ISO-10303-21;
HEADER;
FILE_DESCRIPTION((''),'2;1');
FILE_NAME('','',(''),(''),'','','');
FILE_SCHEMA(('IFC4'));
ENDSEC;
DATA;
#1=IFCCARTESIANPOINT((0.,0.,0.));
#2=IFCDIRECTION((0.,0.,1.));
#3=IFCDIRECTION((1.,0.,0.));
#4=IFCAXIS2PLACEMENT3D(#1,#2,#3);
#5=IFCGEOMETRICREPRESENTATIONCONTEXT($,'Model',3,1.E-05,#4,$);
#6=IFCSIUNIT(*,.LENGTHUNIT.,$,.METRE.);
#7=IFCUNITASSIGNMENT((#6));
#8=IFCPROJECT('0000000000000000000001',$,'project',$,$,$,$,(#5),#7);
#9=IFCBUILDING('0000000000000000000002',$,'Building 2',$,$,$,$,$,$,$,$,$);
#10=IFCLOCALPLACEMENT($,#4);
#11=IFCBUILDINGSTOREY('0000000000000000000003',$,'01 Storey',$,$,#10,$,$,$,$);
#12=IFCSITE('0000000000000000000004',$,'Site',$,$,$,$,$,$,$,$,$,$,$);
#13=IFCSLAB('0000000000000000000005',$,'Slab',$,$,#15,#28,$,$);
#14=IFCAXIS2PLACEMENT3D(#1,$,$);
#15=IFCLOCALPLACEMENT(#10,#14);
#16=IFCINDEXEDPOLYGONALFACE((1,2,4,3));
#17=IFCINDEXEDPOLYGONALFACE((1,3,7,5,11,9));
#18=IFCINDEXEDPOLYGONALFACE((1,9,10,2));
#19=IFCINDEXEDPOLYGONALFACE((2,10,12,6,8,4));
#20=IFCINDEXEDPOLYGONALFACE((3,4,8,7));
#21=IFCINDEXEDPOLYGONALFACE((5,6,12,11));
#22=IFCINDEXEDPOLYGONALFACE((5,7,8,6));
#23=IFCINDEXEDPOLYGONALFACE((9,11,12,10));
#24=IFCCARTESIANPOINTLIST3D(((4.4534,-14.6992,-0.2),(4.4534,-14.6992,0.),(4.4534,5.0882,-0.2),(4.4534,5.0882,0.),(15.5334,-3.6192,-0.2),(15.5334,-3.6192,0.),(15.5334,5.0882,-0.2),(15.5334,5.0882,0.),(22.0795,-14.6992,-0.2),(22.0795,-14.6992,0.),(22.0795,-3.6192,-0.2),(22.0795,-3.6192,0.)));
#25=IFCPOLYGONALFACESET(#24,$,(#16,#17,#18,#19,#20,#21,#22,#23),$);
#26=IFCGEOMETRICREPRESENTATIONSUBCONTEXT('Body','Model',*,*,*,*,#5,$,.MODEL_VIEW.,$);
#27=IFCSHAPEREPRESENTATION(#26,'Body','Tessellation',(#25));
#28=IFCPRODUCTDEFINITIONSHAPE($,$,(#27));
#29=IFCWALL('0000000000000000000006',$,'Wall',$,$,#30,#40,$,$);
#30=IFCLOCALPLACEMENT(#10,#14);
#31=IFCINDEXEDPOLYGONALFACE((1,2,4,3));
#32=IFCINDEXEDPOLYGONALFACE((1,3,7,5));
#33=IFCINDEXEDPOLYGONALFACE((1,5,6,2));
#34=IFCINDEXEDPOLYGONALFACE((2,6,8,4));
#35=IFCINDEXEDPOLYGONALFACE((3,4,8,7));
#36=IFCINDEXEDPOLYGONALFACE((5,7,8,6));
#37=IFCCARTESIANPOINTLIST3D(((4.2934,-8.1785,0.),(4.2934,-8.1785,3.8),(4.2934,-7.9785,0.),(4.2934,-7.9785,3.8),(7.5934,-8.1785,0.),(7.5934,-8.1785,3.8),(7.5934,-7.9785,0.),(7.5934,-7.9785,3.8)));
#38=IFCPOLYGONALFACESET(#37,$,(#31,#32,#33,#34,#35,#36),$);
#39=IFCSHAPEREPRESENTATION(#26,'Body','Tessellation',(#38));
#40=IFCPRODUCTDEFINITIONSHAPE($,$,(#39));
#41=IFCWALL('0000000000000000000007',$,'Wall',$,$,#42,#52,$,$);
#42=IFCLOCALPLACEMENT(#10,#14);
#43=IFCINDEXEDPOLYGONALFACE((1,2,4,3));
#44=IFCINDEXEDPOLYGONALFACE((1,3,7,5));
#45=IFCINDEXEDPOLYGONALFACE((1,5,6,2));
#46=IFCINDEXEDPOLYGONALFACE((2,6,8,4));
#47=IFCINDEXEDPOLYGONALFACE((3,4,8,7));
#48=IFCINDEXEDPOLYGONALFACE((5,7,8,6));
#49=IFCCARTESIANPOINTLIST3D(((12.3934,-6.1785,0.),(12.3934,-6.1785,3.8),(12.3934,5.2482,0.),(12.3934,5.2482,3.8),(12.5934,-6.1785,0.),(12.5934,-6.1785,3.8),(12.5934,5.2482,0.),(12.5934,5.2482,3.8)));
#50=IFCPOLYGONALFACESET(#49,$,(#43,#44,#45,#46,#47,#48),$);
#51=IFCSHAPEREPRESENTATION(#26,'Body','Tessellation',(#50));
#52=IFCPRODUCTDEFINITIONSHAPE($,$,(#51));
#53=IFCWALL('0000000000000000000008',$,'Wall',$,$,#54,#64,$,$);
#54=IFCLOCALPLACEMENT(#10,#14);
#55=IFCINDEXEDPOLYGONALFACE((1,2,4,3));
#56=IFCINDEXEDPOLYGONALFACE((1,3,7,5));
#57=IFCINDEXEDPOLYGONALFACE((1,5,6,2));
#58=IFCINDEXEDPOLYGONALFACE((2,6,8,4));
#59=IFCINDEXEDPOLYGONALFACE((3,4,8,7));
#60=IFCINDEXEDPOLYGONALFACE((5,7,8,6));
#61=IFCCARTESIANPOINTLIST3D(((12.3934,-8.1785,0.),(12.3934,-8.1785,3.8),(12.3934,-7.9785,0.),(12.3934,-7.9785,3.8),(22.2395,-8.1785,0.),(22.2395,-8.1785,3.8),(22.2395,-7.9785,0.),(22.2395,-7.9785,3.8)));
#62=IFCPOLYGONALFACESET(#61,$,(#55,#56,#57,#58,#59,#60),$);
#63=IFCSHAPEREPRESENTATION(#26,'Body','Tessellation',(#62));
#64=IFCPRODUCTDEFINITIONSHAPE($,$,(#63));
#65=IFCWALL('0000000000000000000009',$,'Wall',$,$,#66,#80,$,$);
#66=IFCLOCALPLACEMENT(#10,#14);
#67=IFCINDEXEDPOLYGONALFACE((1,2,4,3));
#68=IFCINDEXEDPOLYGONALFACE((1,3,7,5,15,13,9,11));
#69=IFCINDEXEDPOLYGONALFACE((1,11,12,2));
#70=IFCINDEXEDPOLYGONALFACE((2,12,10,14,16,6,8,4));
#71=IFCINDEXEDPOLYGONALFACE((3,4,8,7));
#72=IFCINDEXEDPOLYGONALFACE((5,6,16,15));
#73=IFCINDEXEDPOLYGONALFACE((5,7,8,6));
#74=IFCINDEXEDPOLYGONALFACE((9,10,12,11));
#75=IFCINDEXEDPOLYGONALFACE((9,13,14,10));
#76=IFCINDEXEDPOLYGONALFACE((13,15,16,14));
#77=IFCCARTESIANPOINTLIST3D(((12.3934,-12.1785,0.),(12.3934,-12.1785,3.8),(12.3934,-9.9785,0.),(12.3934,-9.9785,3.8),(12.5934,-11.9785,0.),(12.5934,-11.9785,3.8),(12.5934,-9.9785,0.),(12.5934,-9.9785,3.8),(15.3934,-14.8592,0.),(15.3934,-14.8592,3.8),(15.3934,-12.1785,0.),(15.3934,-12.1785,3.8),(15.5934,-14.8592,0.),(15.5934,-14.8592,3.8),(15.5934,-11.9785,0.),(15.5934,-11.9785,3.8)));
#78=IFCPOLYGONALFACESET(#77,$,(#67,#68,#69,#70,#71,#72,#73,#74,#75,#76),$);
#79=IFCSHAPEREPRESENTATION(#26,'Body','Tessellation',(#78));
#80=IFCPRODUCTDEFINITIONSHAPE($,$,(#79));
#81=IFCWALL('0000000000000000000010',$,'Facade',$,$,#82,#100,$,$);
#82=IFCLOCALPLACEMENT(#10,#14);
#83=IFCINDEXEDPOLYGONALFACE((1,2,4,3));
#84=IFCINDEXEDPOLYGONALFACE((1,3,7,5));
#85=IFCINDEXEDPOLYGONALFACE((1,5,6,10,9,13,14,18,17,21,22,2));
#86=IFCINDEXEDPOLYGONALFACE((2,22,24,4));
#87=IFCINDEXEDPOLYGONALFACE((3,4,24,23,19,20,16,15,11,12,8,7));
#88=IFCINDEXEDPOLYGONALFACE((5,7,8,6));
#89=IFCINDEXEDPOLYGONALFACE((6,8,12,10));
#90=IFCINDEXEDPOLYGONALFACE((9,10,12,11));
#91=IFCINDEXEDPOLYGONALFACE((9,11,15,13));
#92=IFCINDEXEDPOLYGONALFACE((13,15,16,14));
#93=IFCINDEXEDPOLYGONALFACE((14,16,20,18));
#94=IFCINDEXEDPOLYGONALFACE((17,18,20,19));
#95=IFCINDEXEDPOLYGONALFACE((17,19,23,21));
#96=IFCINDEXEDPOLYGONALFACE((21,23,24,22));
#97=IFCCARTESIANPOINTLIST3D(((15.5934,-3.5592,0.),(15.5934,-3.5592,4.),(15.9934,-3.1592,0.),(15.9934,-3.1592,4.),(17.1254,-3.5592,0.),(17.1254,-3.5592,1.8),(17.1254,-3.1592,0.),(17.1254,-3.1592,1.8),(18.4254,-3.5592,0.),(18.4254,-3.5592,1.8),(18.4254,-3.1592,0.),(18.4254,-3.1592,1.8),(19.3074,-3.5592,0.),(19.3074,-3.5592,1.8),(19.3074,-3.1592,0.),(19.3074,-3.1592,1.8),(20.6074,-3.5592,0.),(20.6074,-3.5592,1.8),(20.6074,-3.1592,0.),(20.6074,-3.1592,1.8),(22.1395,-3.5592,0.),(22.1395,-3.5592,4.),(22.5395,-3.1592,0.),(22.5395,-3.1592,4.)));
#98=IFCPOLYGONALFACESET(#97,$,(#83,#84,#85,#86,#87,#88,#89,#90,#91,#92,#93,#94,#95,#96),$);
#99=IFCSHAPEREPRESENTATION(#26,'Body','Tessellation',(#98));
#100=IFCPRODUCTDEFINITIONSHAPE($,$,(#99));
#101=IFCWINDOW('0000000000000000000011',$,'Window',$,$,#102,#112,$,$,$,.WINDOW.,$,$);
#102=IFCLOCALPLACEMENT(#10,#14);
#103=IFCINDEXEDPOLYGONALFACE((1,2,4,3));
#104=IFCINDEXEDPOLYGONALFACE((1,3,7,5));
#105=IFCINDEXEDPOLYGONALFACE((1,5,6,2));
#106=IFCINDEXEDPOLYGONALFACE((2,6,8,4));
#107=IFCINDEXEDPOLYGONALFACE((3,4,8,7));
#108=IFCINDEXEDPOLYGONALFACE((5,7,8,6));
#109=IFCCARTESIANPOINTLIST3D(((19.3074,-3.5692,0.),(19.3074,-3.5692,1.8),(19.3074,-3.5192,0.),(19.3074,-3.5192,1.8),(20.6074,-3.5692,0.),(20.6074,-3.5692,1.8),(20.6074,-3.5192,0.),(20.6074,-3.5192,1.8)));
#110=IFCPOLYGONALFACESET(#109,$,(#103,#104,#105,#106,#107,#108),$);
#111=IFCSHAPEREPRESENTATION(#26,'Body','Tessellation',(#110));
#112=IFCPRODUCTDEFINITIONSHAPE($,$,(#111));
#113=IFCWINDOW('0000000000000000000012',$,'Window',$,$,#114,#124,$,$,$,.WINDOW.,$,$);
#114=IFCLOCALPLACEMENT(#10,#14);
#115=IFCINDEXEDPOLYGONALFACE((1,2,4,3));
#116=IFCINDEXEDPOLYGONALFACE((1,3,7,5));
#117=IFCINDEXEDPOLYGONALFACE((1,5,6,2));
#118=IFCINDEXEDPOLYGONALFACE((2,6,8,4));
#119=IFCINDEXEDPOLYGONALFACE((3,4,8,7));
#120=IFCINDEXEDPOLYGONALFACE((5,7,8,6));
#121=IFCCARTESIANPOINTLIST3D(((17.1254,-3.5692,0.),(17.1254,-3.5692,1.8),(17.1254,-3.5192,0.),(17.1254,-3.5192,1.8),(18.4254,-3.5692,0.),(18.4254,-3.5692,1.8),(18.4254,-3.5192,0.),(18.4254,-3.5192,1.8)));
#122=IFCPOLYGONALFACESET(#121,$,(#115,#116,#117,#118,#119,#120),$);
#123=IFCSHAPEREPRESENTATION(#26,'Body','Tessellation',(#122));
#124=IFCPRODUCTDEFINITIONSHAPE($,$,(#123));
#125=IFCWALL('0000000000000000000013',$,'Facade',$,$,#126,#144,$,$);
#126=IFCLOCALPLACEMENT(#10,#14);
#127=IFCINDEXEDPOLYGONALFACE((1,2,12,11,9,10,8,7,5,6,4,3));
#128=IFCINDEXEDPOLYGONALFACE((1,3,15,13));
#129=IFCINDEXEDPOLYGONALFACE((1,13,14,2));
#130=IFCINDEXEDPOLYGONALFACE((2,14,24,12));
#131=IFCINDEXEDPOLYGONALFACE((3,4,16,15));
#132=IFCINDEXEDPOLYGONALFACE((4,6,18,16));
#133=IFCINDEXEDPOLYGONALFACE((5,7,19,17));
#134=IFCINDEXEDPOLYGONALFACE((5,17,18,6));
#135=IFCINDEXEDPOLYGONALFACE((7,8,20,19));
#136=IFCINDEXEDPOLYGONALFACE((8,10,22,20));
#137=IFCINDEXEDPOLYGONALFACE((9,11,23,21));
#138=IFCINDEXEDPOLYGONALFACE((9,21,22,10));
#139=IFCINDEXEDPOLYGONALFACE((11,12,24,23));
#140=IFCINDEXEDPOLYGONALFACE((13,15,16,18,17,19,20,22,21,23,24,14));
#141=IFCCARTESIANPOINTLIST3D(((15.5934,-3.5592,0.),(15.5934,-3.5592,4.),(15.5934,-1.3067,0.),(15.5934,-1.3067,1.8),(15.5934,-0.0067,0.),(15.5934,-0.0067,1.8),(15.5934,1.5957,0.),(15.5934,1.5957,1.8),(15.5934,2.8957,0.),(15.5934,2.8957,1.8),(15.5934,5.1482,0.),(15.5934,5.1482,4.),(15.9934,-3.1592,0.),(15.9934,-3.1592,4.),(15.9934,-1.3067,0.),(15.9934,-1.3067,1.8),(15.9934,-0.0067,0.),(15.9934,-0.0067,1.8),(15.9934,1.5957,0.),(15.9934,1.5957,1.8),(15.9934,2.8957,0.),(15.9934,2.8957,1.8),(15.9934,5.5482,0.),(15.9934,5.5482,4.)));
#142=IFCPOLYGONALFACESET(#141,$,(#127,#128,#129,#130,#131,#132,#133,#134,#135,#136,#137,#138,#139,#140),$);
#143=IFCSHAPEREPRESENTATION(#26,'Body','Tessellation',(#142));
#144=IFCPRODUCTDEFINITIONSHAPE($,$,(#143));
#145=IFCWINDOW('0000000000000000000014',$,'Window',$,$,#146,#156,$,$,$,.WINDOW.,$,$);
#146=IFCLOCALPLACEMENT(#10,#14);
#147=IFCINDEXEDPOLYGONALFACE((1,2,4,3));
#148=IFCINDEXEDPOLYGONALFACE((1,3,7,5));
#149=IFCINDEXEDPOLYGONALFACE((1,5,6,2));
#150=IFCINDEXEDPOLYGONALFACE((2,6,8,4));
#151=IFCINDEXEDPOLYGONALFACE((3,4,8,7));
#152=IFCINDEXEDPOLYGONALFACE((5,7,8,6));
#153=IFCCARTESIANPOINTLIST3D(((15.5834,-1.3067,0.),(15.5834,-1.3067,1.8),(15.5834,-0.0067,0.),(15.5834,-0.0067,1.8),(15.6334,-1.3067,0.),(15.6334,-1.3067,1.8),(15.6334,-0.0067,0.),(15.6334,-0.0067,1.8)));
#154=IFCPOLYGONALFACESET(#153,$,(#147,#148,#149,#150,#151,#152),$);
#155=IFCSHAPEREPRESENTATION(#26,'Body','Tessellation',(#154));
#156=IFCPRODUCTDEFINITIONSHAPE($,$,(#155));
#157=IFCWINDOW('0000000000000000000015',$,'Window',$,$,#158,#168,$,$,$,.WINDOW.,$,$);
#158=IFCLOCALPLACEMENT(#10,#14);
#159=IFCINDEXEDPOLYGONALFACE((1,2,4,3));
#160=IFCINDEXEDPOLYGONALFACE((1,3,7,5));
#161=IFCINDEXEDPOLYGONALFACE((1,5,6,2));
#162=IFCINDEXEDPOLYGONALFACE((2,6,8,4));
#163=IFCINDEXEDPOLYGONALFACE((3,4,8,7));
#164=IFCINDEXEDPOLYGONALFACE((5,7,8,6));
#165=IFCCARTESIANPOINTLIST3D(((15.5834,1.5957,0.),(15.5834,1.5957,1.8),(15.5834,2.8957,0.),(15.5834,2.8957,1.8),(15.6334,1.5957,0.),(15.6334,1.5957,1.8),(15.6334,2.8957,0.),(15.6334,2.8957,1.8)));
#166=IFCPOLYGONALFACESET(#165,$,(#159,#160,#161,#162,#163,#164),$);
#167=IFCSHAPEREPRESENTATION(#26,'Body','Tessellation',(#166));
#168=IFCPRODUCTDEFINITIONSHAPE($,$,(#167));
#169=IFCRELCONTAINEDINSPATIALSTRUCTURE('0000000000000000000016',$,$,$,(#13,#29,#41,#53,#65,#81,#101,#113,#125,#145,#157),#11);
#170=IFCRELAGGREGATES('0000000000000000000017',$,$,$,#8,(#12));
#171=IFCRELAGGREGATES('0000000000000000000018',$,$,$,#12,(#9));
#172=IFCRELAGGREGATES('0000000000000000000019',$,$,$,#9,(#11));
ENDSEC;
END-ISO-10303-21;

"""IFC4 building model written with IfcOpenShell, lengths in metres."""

from ifc_helpers import new_model, si_unit, origin_with_axes, place, context, subcontext, project, spatial, line, indexed_curve, outline, extrude, element, fill, save


model = new_model("IFC4")

# Units and contexts
model_context = context("Model", 3, precision=1e-05, world=origin_with_axes())
body_context = subcontext(model_context, "Body", "Model", "MODEL_VIEW")
ifc_project = project(units=[si_unit("LENGTHUNIT", "METRE")], contexts=[model_context])

# Site, building, storey
site = spatial("IfcSite", under=ifc_project, Name="Site")
building = spatial("IfcBuilding", under=site, Name="Building 2")
storey_placement = place(None, origin_with_axes())
storey = spatial("IfcBuildingStorey", under=building, at=storey_placement, Name="01 Storey")

# Slab
slab_placement = place(storey_placement, origin_with_axes())
element("IfcSlab", 1, at=slab_placement, inside=storey, Name="Slab", context=body_context, shape_type="SweptSolid", body=[
    extrude(outline(indexed_curve([(22.0795, -3.6192), (15.5334, -3.6192), (15.5334, 5.0882), (4.4534, 5.0882), (4.4534, -14.6992), (22.0795, -14.6992)], segments=[line(1, 2), line(2, 3), line(3, 4), line(4, 5), line(5, 6)])), origin_with_axes(), (0.0, 0.0, -1.0), 0.2),
])

# Walls
wall_1_placement = place(storey_placement, origin_with_axes())
element("IfcWall", 2, at=wall_1_placement, inside=storey, Name="Wall", context=body_context, shape_type="SweptSolid", body=[
    extrude(outline(indexed_curve([(7.5934, -7.9785), (4.2934, -7.9785), (4.2934, -8.1785), (7.5934, -8.1785)], segments=[line(1, 2), line(2, 3), line(3, 4)])), origin_with_axes(), (0.0, 0.0, 1.0), 3.8),
])
wall_2_placement = place(storey_placement, origin_with_axes())
element("IfcWall", 3, at=wall_2_placement, inside=storey, Name="Wall", context=body_context, shape_type="SweptSolid", body=[
    extrude(outline(indexed_curve([(12.5934, 5.2482), (12.3934, 5.2482), (12.3934, -6.1785), (12.5934, -6.1785)], segments=[line(1, 2), line(2, 3), line(3, 4)])), origin_with_axes(), (0.0, 0.0, 1.0), 3.8),
])
wall_3_placement = place(storey_placement, origin_with_axes())
element("IfcWall", 4, at=wall_3_placement, inside=storey, Name="Wall", context=body_context, shape_type="SweptSolid", body=[
    extrude(outline(indexed_curve([(22.2395, -7.9785), (12.3934, -7.9785), (12.3934, -8.1785), (22.2395, -8.1785)], segments=[line(1, 2), line(2, 3), line(3, 4)])), origin_with_axes(), (0.0, 0.0, 1.0), 3.8),
])
wall_4_placement = place(storey_placement, origin_with_axes())
element("IfcWall", 5, at=wall_4_placement, inside=storey, Name="Wall", context=body_context, shape_type="SweptSolid", body=[
    extrude(outline(indexed_curve([(15.5934, -11.9785), (12.5934, -11.9785), (12.5934, -9.9785), (12.3934, -9.9785), (12.3934, -12.1785), (15.3934, -12.1785), (15.3934, -14.8592), (15.5934, -14.8592)], segments=[line(1, 2), line(2, 3), line(3, 4), line(4, 5), line(5, 6), line(6, 7), line(7, 8)])), origin_with_axes(), (0.0, 0.0, 1.0), 3.8),
])

# Walls, openings, windows
wall_5_placement = place(storey_placement, origin_with_axes())
wall_5 = element("IfcWall", 6, at=wall_5_placement, inside=storey, Name="Facade", context=body_context, shape_type="SweptSolid", body=[
    extrude(outline(indexed_curve([(22.1395, -3.5592), (15.5934, -3.5592), (15.9934, -3.1592), (22.5395, -3.1592)], segments=[line(1, 2), line(2, 3), line(3, 4)])), origin_with_axes(), (0.0, 0.0, 1.0), 4.0),
])
opening_1_placement = place(wall_5_placement, origin_with_axes())
opening_1 = element("IfcOpeningElement", 7, at=opening_1_placement, cuts=wall_5, context=body_context, shape_type="SweptSolid", body=[
    extrude(outline(indexed_curve([(20.6074, -3.1192), (20.6074, -3.6192), (19.3074, -3.6192), (19.3074, -3.1192)], segments=[line(1, 2), line(2, 3), line(3, 4)])), origin_with_axes(), (0.0, 0.0, 1.0), 1.8),
])
opening_2_placement = place(wall_5_placement, origin_with_axes())
opening_2 = element("IfcOpeningElement", 8, at=opening_2_placement, cuts=wall_5, context=body_context, shape_type="SweptSolid", body=[
    extrude(outline(indexed_curve([(18.4254, -3.1192), (18.4254, -3.6192), (17.1254, -3.6192), (17.1254, -3.1192)], segments=[line(1, 2), line(2, 3), line(3, 4)])), origin_with_axes(), (0.0, 0.0, 1.0), 1.8),
])
window_1_placement = place(storey_placement, origin_with_axes())
window_1 = element("IfcWindow", 9, at=window_1_placement, inside=storey, Name="Window", PredefinedType="WINDOW", context=body_context, shape_type="SweptSolid", body=[
    extrude(outline(indexed_curve([(20.6074, -3.5192), (20.6074, -3.5692), (19.3074, -3.5692), (19.3074, -3.5192)], segments=[line(1, 2), line(2, 3), line(3, 4)])), origin_with_axes(), (0.0, 0.0, 1.0), 1.8),
])
fill(opening_1, window_1)
window_2_placement = place(storey_placement, origin_with_axes())
window_2 = element("IfcWindow", 10, at=window_2_placement, inside=storey, Name="Window", PredefinedType="WINDOW", context=body_context, shape_type="SweptSolid", body=[
    extrude(outline(indexed_curve([(18.4254, -3.5192), (18.4254, -3.5692), (17.1254, -3.5692), (17.1254, -3.5192)], segments=[line(1, 2), line(2, 3), line(3, 4)])), origin_with_axes(), (0.0, 0.0, 1.0), 1.8),
])
fill(opening_2, window_2)
wall_6_placement = place(storey_placement, origin_with_axes())
wall_6 = element("IfcWall", 11, at=wall_6_placement, inside=storey, Name="Facade", context=body_context, shape_type="SweptSolid", body=[
    extrude(outline(indexed_curve([(15.5934, -3.5592), (15.5934, 5.1482), (15.9934, 5.5482), (15.9934, -3.1592)], segments=[line(1, 2), line(2, 3), line(3, 4)])), origin_with_axes(), (0.0, 0.0, 1.0), 4.0),
])
opening_3_placement = place(wall_6_placement, origin_with_axes())
opening_3 = element("IfcOpeningElement", 12, at=opening_3_placement, cuts=wall_6, context=body_context, shape_type="SweptSolid", body=[
    extrude(outline(indexed_curve([(16.0334, -1.3067), (15.5334, -1.3067), (15.5334, -0.0067), (16.0334, -0.0067)], segments=[line(1, 2), line(2, 3), line(3, 4)])), origin_with_axes(), (0.0, 0.0, 1.0), 1.8),
])
opening_4_placement = place(wall_6_placement, origin_with_axes())
opening_4 = element("IfcOpeningElement", 13, at=opening_4_placement, cuts=wall_6, context=body_context, shape_type="SweptSolid", body=[
    extrude(outline(indexed_curve([(16.0334, 1.5957), (15.5334, 1.5957), (15.5334, 2.8957), (16.0334, 2.8957)], segments=[line(1, 2), line(2, 3), line(3, 4)])), origin_with_axes(), (0.0, 0.0, 1.0), 1.8),
])
window_3_placement = place(storey_placement, origin_with_axes())
window_3 = element("IfcWindow", 14, at=window_3_placement, inside=storey, Name="Window", PredefinedType="WINDOW", context=body_context, shape_type="SweptSolid", body=[
    extrude(outline(indexed_curve([(15.6334, -1.3067), (15.5834, -1.3067), (15.5834, -0.0067), (15.6334, -0.0067)], segments=[line(1, 2), line(2, 3), line(3, 4)])), origin_with_axes(), (0.0, 0.0, 1.0), 1.8),
])
fill(opening_3, window_3)
window_4_placement = place(storey_placement, origin_with_axes())
window_4 = element("IfcWindow", 15, at=window_4_placement, inside=storey, Name="Window", PredefinedType="WINDOW", context=body_context, shape_type="SweptSolid", body=[
    extrude(outline(indexed_curve([(15.6334, 1.5957), (15.5834, 1.5957), (15.5834, 2.8957), (15.6334, 2.8957)], segments=[line(1, 2), line(2, 3), line(3, 4)])), origin_with_axes(), (0.0, 0.0, 1.0), 1.8),
])
fill(opening_4, window_4)

save(model, "model.ifc")
